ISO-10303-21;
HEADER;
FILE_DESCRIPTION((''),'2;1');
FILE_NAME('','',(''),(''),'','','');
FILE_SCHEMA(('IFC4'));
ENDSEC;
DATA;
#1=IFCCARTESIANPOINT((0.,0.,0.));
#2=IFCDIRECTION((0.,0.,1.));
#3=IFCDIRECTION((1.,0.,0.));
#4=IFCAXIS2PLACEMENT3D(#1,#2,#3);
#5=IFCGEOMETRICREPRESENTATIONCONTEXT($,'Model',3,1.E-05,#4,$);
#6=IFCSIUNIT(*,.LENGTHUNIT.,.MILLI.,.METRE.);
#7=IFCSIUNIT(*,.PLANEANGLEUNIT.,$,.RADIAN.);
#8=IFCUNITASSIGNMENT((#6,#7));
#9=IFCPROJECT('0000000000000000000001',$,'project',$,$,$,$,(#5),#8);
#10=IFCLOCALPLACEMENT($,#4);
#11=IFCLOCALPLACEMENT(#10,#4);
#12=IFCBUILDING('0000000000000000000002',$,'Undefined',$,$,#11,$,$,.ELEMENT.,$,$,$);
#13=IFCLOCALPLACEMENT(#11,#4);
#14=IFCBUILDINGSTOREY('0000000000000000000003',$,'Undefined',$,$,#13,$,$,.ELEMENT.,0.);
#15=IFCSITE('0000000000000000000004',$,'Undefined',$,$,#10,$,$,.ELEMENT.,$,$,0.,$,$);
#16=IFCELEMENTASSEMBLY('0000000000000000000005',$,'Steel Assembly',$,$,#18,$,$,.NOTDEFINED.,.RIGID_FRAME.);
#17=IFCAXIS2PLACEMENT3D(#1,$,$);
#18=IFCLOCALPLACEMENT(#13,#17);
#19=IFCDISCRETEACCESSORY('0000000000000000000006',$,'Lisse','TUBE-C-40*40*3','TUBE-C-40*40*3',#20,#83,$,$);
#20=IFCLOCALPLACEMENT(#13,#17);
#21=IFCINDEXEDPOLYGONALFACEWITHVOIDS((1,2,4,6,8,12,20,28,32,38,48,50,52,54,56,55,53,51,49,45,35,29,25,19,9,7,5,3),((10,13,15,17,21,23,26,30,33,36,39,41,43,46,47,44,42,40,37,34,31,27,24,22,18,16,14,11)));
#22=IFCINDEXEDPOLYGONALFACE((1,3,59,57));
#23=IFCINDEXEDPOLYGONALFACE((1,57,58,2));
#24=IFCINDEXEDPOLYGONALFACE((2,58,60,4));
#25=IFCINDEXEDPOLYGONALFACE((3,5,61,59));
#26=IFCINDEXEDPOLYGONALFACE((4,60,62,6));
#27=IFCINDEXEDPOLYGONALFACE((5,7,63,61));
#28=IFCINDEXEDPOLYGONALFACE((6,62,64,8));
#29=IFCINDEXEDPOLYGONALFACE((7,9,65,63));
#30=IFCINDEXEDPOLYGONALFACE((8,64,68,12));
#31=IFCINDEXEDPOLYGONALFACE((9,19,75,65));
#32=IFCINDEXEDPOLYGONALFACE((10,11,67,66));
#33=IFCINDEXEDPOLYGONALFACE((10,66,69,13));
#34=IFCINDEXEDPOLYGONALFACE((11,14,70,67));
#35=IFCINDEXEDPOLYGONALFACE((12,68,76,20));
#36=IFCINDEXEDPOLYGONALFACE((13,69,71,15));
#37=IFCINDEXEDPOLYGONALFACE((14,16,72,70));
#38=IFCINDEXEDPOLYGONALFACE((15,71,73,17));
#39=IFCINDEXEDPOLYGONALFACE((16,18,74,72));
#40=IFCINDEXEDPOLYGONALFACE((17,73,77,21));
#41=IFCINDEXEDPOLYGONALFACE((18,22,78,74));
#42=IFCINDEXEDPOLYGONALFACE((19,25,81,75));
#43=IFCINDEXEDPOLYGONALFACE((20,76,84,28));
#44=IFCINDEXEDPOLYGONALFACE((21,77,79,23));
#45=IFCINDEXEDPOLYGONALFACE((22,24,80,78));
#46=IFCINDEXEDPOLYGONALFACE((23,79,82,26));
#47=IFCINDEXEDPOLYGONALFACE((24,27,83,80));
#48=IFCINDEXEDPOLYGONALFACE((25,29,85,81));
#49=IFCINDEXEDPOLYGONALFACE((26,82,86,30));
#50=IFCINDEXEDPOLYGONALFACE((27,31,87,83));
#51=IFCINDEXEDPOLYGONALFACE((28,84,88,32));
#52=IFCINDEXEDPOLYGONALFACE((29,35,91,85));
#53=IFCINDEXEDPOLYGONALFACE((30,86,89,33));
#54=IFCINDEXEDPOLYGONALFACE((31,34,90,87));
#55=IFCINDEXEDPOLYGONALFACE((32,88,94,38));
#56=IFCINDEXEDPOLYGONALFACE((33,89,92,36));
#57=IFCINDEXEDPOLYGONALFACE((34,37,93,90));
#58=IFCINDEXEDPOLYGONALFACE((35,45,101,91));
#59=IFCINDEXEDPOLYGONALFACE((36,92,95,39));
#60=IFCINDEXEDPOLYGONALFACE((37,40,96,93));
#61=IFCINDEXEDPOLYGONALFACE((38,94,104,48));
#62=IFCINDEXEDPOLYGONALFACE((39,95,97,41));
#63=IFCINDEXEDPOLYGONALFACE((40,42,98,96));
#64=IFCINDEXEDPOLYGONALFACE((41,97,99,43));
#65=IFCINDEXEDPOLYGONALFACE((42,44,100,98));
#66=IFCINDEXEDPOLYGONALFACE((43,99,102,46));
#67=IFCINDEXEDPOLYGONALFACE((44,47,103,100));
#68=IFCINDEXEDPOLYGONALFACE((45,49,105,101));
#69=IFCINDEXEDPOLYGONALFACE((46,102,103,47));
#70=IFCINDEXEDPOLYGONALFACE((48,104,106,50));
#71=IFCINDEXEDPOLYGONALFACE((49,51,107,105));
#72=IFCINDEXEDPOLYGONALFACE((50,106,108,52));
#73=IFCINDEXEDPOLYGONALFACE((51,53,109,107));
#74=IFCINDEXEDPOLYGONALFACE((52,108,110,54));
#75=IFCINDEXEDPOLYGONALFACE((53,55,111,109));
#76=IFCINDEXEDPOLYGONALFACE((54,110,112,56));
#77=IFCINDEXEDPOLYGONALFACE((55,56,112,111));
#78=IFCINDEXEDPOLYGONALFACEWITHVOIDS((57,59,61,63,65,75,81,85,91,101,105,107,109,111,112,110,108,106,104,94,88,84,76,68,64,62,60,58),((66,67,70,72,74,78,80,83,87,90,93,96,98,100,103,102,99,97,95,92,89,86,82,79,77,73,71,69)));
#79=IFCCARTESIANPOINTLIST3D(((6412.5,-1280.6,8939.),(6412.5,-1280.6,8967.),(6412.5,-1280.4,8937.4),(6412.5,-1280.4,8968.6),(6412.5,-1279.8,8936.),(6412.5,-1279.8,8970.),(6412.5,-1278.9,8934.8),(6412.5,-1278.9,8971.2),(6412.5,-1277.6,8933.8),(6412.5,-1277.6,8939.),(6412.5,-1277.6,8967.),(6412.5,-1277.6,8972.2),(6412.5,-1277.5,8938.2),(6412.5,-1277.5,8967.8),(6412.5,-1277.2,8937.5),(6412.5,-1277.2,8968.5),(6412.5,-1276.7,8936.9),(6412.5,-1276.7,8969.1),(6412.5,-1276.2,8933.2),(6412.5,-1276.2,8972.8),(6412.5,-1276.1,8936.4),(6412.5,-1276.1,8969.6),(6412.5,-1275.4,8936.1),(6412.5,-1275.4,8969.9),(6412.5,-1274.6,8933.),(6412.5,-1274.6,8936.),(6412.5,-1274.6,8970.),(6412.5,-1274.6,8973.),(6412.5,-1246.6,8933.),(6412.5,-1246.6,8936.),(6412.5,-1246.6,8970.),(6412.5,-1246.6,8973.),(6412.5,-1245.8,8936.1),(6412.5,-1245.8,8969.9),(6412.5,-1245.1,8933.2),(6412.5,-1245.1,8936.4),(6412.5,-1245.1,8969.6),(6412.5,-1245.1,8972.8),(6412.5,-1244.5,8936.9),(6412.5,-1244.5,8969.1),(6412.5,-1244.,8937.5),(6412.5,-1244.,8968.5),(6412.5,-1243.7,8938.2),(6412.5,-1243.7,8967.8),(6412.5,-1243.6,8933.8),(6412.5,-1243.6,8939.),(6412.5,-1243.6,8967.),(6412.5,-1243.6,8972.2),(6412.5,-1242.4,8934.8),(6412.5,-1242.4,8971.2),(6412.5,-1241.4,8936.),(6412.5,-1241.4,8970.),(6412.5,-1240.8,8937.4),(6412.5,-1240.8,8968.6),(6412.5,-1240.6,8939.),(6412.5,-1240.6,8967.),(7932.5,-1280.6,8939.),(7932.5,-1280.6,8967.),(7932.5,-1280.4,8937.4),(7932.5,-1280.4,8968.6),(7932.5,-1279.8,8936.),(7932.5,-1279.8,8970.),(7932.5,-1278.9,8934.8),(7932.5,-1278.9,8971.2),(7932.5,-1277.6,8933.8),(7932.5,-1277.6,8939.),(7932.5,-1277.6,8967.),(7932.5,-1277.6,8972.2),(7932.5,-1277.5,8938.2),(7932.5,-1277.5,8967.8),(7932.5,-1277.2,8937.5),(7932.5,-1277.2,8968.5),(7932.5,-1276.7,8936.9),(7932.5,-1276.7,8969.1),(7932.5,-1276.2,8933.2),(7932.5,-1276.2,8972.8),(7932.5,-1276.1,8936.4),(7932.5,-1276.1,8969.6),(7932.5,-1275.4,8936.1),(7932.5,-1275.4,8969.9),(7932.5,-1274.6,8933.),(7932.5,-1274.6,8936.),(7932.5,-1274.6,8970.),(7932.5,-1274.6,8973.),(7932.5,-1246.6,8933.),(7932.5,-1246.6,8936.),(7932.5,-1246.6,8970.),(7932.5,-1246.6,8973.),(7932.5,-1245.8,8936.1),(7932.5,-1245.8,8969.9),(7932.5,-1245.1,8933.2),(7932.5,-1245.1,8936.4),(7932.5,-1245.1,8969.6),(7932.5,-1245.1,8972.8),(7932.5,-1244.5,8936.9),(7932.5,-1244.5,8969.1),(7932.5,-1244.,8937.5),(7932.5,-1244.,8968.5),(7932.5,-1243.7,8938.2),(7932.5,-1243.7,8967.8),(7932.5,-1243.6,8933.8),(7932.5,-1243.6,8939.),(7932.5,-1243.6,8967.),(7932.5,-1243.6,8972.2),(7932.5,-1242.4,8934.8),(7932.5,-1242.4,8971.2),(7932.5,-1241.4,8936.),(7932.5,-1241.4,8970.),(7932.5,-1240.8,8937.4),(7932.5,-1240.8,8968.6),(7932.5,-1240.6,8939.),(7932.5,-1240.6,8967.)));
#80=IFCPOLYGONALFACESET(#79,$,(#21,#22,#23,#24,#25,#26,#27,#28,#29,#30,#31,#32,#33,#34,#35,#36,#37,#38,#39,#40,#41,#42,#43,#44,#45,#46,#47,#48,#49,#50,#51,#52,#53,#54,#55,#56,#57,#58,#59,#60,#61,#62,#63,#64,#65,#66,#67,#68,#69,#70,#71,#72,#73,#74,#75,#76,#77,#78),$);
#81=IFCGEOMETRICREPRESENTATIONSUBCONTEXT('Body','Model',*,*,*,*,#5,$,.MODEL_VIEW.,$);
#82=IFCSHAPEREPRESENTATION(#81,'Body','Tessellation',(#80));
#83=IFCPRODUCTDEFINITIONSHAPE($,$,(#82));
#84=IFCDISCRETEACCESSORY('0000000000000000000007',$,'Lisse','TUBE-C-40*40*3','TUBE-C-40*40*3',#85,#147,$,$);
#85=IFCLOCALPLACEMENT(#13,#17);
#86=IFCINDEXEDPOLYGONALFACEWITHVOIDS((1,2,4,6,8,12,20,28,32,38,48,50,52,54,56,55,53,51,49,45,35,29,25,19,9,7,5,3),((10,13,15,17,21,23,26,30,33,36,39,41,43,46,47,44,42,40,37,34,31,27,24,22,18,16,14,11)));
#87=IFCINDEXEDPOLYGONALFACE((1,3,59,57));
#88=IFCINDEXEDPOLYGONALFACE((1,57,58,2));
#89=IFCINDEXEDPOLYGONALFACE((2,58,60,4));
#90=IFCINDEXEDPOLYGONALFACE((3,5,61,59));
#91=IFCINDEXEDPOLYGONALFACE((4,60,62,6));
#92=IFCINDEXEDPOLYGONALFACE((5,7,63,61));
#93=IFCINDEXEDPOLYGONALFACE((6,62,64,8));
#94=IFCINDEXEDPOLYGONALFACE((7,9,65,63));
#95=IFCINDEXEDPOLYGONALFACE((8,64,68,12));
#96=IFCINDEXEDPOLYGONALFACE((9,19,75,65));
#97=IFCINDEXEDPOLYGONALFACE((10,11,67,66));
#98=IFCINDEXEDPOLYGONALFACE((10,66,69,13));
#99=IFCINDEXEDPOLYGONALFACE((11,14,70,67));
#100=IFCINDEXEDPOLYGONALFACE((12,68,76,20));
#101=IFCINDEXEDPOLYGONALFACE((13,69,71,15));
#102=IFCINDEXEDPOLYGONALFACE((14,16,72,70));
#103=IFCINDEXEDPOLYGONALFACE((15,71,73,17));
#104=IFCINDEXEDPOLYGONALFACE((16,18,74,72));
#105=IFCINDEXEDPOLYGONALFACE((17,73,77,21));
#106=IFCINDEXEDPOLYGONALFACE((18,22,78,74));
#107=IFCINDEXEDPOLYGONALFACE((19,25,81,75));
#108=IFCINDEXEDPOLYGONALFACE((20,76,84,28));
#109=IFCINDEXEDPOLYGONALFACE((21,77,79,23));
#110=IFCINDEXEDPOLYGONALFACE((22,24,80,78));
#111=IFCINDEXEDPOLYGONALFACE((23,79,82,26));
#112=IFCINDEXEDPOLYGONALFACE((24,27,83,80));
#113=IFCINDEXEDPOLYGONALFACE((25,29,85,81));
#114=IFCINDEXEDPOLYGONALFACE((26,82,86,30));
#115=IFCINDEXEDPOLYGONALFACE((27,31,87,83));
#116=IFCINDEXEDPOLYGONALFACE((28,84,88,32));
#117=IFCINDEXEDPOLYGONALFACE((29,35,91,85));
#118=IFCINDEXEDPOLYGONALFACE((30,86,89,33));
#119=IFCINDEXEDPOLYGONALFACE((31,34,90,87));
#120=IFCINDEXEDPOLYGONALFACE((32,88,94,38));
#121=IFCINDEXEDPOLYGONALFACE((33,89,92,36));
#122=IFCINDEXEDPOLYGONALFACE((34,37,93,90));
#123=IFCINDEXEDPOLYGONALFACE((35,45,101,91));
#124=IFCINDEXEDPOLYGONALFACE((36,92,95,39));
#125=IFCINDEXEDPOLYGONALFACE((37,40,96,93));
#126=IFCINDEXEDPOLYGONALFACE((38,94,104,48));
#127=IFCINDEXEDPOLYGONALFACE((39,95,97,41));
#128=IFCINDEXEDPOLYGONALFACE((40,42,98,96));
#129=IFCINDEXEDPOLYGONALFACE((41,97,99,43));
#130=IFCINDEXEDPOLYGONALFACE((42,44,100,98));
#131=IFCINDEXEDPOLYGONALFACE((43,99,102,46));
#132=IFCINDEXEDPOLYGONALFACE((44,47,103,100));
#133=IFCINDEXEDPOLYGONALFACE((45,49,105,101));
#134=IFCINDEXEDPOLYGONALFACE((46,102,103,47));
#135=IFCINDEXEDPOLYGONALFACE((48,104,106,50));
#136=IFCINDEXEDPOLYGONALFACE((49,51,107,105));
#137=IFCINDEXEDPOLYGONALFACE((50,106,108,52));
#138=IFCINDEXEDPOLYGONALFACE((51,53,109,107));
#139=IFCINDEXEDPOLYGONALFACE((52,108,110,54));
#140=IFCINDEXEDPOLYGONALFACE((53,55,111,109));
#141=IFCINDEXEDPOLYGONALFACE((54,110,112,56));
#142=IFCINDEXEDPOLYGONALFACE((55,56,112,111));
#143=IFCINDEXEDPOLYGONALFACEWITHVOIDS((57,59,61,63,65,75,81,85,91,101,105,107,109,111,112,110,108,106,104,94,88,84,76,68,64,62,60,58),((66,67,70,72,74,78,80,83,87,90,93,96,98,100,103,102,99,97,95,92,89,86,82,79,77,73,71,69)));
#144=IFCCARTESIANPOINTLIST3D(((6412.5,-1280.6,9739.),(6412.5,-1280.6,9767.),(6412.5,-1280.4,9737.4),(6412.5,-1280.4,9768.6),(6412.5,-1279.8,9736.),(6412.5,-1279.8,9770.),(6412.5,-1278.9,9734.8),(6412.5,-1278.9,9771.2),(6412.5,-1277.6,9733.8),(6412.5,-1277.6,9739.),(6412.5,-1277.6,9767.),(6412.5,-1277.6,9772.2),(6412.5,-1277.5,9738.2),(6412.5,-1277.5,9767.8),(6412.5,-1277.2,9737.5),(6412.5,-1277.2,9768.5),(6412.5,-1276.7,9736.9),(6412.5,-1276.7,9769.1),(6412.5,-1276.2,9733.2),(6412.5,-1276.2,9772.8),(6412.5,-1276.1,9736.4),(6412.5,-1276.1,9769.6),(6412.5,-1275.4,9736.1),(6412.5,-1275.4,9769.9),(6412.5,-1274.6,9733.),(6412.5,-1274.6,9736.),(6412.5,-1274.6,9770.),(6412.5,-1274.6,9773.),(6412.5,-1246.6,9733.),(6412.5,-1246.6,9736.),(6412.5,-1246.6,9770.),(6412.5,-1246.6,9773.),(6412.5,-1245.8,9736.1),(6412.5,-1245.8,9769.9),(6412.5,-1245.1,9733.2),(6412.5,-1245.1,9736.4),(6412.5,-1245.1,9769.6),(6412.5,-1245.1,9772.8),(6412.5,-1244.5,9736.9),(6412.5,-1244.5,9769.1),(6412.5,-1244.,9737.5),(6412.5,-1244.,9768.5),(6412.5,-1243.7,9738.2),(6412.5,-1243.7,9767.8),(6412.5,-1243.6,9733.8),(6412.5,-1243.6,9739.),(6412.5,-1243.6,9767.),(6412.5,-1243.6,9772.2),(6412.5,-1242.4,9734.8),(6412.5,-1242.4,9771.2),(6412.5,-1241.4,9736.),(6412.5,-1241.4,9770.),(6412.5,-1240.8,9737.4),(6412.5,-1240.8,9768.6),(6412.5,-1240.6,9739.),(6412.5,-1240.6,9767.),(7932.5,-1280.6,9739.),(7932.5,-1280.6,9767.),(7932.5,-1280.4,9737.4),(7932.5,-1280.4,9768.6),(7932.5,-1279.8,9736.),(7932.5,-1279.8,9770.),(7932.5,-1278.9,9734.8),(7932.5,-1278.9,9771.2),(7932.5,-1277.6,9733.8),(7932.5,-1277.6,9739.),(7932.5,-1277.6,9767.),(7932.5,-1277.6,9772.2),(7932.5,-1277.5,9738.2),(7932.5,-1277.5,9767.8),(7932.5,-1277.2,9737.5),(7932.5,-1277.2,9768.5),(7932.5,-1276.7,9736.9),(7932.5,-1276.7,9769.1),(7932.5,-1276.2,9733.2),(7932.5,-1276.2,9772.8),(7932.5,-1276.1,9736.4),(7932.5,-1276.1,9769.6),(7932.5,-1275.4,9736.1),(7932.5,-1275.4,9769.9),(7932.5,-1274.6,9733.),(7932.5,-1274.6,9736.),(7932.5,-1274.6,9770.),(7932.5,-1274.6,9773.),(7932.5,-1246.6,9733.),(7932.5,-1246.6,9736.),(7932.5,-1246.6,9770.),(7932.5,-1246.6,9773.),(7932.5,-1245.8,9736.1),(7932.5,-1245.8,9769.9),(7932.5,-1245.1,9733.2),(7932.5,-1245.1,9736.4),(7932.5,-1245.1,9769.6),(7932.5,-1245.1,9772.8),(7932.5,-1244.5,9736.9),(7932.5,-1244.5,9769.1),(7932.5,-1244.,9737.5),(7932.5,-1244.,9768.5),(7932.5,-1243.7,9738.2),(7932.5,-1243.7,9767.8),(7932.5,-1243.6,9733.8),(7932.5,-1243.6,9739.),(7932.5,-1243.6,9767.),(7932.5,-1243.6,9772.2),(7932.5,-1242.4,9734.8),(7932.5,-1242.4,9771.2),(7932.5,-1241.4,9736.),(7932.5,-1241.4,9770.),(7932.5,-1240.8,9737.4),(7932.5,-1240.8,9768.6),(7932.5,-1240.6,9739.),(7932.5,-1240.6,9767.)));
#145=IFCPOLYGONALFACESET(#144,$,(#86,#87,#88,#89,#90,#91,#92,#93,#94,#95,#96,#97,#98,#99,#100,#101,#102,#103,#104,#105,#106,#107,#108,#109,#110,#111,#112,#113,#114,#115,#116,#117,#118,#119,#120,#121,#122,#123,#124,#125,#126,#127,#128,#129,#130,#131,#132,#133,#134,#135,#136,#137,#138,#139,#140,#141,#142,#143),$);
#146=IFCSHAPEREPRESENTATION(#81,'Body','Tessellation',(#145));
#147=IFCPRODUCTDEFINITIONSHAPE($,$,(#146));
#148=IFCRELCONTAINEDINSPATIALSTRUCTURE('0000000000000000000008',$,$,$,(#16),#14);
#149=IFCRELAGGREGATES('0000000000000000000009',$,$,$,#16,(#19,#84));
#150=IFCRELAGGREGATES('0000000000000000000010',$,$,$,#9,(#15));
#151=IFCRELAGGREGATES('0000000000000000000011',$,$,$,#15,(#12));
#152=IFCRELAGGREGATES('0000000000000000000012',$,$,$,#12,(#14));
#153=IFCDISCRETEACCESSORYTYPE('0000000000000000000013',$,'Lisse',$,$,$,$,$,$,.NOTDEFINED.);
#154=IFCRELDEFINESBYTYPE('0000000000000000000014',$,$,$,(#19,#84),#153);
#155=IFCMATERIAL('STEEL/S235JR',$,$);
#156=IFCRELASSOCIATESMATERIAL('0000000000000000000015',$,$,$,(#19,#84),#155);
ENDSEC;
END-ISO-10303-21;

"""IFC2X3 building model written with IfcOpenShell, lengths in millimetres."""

from ifc_helpers import new_model, si_unit, frame, origin_with_axes, origin_2d_with_axis, place, context, subcontext, project, spatial, hollow_rectangle, extrude, material, type_object, element, aggregate, save


model = new_model("IFC2X3")

# Units and contexts
model_context = context("Model", 3, precision=1e-05, world=origin_with_axes())
body_context = subcontext(model_context, "Body", "Model", "MODEL_VIEW")
ifc_project = project(units=[si_unit("LENGTHUNIT", "METRE", prefix="MILLI"), si_unit("PLANEANGLEUNIT", "RADIAN")], contexts=[model_context])

# Site, building, storey
site_placement = place(None, origin_with_axes())
site = spatial("IfcSite", under=ifc_project, at=site_placement, Name="Undefined", CompositionType="ELEMENT", RefElevation=0.0)
building_placement = place(site_placement, origin_with_axes())
building = spatial("IfcBuilding", under=site, at=building_placement, Name="Undefined", CompositionType="ELEMENT")
storey_placement = place(building_placement, origin_with_axes())
storey = spatial("IfcBuildingStorey", under=building, at=storey_placement, Name="Undefined", CompositionType="ELEMENT", Elevation=0.0)

# Element assembly
assembly_1_placement = place(storey_placement, origin_with_axes())
assembly_1 = element("IfcElementAssembly", 1, at=assembly_1_placement, inside=storey, Name="Steel Assembly", AssemblyPlace="NOTDEFINED", PredefinedType="RIGID_FRAME")
ifc_material_1 = material(Name="STEEL/S235JR")

# Discrete accessories
discrete_accessory_type_1 = type_object("IfcDiscreteAccessoryType", Name="Lisse")
discrete_accessory_1_placement = place(assembly_1_placement, frame((7932.5, -1260.6, 8953.0), z_axis=(0.0, 1.0, 0.0), x_axis=(-1.0, 0.0, 0.0)))
discrete_accessory_1 = element("IfcDiscreteAccessory", 2, at=discrete_accessory_1_placement, type_object=discrete_accessory_type_1, material=ifc_material_1, Name="Lisse", Description="TUBE-C-40*40*3", ObjectType="TUBE-C-40*40*3", context=body_context, shape_type="SweptSolid", body=[
    extrude(hollow_rectangle(XDim=40.0, YDim=40.0, WallThickness=3.0, InnerFilletRadius=3.0, OuterFilletRadius=6.0, at=origin_2d_with_axis()), frame((1520.0, 0.0, 0.0), z_axis=(-1.0, 0.0, 0.0), x_axis=(0.0, -1.0, 0.0)), (0.0, 0.0, 1.0), 1520.0),
])
discrete_accessory_2_placement = place(assembly_1_placement, frame((7932.5, -1260.6, 9753.0), z_axis=(0.0, 1.0, 0.0), x_axis=(-1.0, 0.0, 0.0)))
discrete_accessory_2 = element("IfcDiscreteAccessory", 3, at=discrete_accessory_2_placement, type_object=discrete_accessory_type_1, material=ifc_material_1, Name="Lisse", Description="TUBE-C-40*40*3", ObjectType="TUBE-C-40*40*3", context=body_context, shape_type="SweptSolid", body=[
    extrude(hollow_rectangle(XDim=40.0, YDim=40.0, WallThickness=3.0, InnerFilletRadius=3.0, OuterFilletRadius=6.0, at=origin_2d_with_axis()), frame((1520.0, 0.0, 0.0), z_axis=(-1.0, 0.0, 0.0), x_axis=(0.0, -1.0, 0.0)), (0.0, 0.0, 1.0), 1520.0),
])
aggregate(assembly_1, [discrete_accessory_1, discrete_accessory_2])

save(model, "model.ifc")
